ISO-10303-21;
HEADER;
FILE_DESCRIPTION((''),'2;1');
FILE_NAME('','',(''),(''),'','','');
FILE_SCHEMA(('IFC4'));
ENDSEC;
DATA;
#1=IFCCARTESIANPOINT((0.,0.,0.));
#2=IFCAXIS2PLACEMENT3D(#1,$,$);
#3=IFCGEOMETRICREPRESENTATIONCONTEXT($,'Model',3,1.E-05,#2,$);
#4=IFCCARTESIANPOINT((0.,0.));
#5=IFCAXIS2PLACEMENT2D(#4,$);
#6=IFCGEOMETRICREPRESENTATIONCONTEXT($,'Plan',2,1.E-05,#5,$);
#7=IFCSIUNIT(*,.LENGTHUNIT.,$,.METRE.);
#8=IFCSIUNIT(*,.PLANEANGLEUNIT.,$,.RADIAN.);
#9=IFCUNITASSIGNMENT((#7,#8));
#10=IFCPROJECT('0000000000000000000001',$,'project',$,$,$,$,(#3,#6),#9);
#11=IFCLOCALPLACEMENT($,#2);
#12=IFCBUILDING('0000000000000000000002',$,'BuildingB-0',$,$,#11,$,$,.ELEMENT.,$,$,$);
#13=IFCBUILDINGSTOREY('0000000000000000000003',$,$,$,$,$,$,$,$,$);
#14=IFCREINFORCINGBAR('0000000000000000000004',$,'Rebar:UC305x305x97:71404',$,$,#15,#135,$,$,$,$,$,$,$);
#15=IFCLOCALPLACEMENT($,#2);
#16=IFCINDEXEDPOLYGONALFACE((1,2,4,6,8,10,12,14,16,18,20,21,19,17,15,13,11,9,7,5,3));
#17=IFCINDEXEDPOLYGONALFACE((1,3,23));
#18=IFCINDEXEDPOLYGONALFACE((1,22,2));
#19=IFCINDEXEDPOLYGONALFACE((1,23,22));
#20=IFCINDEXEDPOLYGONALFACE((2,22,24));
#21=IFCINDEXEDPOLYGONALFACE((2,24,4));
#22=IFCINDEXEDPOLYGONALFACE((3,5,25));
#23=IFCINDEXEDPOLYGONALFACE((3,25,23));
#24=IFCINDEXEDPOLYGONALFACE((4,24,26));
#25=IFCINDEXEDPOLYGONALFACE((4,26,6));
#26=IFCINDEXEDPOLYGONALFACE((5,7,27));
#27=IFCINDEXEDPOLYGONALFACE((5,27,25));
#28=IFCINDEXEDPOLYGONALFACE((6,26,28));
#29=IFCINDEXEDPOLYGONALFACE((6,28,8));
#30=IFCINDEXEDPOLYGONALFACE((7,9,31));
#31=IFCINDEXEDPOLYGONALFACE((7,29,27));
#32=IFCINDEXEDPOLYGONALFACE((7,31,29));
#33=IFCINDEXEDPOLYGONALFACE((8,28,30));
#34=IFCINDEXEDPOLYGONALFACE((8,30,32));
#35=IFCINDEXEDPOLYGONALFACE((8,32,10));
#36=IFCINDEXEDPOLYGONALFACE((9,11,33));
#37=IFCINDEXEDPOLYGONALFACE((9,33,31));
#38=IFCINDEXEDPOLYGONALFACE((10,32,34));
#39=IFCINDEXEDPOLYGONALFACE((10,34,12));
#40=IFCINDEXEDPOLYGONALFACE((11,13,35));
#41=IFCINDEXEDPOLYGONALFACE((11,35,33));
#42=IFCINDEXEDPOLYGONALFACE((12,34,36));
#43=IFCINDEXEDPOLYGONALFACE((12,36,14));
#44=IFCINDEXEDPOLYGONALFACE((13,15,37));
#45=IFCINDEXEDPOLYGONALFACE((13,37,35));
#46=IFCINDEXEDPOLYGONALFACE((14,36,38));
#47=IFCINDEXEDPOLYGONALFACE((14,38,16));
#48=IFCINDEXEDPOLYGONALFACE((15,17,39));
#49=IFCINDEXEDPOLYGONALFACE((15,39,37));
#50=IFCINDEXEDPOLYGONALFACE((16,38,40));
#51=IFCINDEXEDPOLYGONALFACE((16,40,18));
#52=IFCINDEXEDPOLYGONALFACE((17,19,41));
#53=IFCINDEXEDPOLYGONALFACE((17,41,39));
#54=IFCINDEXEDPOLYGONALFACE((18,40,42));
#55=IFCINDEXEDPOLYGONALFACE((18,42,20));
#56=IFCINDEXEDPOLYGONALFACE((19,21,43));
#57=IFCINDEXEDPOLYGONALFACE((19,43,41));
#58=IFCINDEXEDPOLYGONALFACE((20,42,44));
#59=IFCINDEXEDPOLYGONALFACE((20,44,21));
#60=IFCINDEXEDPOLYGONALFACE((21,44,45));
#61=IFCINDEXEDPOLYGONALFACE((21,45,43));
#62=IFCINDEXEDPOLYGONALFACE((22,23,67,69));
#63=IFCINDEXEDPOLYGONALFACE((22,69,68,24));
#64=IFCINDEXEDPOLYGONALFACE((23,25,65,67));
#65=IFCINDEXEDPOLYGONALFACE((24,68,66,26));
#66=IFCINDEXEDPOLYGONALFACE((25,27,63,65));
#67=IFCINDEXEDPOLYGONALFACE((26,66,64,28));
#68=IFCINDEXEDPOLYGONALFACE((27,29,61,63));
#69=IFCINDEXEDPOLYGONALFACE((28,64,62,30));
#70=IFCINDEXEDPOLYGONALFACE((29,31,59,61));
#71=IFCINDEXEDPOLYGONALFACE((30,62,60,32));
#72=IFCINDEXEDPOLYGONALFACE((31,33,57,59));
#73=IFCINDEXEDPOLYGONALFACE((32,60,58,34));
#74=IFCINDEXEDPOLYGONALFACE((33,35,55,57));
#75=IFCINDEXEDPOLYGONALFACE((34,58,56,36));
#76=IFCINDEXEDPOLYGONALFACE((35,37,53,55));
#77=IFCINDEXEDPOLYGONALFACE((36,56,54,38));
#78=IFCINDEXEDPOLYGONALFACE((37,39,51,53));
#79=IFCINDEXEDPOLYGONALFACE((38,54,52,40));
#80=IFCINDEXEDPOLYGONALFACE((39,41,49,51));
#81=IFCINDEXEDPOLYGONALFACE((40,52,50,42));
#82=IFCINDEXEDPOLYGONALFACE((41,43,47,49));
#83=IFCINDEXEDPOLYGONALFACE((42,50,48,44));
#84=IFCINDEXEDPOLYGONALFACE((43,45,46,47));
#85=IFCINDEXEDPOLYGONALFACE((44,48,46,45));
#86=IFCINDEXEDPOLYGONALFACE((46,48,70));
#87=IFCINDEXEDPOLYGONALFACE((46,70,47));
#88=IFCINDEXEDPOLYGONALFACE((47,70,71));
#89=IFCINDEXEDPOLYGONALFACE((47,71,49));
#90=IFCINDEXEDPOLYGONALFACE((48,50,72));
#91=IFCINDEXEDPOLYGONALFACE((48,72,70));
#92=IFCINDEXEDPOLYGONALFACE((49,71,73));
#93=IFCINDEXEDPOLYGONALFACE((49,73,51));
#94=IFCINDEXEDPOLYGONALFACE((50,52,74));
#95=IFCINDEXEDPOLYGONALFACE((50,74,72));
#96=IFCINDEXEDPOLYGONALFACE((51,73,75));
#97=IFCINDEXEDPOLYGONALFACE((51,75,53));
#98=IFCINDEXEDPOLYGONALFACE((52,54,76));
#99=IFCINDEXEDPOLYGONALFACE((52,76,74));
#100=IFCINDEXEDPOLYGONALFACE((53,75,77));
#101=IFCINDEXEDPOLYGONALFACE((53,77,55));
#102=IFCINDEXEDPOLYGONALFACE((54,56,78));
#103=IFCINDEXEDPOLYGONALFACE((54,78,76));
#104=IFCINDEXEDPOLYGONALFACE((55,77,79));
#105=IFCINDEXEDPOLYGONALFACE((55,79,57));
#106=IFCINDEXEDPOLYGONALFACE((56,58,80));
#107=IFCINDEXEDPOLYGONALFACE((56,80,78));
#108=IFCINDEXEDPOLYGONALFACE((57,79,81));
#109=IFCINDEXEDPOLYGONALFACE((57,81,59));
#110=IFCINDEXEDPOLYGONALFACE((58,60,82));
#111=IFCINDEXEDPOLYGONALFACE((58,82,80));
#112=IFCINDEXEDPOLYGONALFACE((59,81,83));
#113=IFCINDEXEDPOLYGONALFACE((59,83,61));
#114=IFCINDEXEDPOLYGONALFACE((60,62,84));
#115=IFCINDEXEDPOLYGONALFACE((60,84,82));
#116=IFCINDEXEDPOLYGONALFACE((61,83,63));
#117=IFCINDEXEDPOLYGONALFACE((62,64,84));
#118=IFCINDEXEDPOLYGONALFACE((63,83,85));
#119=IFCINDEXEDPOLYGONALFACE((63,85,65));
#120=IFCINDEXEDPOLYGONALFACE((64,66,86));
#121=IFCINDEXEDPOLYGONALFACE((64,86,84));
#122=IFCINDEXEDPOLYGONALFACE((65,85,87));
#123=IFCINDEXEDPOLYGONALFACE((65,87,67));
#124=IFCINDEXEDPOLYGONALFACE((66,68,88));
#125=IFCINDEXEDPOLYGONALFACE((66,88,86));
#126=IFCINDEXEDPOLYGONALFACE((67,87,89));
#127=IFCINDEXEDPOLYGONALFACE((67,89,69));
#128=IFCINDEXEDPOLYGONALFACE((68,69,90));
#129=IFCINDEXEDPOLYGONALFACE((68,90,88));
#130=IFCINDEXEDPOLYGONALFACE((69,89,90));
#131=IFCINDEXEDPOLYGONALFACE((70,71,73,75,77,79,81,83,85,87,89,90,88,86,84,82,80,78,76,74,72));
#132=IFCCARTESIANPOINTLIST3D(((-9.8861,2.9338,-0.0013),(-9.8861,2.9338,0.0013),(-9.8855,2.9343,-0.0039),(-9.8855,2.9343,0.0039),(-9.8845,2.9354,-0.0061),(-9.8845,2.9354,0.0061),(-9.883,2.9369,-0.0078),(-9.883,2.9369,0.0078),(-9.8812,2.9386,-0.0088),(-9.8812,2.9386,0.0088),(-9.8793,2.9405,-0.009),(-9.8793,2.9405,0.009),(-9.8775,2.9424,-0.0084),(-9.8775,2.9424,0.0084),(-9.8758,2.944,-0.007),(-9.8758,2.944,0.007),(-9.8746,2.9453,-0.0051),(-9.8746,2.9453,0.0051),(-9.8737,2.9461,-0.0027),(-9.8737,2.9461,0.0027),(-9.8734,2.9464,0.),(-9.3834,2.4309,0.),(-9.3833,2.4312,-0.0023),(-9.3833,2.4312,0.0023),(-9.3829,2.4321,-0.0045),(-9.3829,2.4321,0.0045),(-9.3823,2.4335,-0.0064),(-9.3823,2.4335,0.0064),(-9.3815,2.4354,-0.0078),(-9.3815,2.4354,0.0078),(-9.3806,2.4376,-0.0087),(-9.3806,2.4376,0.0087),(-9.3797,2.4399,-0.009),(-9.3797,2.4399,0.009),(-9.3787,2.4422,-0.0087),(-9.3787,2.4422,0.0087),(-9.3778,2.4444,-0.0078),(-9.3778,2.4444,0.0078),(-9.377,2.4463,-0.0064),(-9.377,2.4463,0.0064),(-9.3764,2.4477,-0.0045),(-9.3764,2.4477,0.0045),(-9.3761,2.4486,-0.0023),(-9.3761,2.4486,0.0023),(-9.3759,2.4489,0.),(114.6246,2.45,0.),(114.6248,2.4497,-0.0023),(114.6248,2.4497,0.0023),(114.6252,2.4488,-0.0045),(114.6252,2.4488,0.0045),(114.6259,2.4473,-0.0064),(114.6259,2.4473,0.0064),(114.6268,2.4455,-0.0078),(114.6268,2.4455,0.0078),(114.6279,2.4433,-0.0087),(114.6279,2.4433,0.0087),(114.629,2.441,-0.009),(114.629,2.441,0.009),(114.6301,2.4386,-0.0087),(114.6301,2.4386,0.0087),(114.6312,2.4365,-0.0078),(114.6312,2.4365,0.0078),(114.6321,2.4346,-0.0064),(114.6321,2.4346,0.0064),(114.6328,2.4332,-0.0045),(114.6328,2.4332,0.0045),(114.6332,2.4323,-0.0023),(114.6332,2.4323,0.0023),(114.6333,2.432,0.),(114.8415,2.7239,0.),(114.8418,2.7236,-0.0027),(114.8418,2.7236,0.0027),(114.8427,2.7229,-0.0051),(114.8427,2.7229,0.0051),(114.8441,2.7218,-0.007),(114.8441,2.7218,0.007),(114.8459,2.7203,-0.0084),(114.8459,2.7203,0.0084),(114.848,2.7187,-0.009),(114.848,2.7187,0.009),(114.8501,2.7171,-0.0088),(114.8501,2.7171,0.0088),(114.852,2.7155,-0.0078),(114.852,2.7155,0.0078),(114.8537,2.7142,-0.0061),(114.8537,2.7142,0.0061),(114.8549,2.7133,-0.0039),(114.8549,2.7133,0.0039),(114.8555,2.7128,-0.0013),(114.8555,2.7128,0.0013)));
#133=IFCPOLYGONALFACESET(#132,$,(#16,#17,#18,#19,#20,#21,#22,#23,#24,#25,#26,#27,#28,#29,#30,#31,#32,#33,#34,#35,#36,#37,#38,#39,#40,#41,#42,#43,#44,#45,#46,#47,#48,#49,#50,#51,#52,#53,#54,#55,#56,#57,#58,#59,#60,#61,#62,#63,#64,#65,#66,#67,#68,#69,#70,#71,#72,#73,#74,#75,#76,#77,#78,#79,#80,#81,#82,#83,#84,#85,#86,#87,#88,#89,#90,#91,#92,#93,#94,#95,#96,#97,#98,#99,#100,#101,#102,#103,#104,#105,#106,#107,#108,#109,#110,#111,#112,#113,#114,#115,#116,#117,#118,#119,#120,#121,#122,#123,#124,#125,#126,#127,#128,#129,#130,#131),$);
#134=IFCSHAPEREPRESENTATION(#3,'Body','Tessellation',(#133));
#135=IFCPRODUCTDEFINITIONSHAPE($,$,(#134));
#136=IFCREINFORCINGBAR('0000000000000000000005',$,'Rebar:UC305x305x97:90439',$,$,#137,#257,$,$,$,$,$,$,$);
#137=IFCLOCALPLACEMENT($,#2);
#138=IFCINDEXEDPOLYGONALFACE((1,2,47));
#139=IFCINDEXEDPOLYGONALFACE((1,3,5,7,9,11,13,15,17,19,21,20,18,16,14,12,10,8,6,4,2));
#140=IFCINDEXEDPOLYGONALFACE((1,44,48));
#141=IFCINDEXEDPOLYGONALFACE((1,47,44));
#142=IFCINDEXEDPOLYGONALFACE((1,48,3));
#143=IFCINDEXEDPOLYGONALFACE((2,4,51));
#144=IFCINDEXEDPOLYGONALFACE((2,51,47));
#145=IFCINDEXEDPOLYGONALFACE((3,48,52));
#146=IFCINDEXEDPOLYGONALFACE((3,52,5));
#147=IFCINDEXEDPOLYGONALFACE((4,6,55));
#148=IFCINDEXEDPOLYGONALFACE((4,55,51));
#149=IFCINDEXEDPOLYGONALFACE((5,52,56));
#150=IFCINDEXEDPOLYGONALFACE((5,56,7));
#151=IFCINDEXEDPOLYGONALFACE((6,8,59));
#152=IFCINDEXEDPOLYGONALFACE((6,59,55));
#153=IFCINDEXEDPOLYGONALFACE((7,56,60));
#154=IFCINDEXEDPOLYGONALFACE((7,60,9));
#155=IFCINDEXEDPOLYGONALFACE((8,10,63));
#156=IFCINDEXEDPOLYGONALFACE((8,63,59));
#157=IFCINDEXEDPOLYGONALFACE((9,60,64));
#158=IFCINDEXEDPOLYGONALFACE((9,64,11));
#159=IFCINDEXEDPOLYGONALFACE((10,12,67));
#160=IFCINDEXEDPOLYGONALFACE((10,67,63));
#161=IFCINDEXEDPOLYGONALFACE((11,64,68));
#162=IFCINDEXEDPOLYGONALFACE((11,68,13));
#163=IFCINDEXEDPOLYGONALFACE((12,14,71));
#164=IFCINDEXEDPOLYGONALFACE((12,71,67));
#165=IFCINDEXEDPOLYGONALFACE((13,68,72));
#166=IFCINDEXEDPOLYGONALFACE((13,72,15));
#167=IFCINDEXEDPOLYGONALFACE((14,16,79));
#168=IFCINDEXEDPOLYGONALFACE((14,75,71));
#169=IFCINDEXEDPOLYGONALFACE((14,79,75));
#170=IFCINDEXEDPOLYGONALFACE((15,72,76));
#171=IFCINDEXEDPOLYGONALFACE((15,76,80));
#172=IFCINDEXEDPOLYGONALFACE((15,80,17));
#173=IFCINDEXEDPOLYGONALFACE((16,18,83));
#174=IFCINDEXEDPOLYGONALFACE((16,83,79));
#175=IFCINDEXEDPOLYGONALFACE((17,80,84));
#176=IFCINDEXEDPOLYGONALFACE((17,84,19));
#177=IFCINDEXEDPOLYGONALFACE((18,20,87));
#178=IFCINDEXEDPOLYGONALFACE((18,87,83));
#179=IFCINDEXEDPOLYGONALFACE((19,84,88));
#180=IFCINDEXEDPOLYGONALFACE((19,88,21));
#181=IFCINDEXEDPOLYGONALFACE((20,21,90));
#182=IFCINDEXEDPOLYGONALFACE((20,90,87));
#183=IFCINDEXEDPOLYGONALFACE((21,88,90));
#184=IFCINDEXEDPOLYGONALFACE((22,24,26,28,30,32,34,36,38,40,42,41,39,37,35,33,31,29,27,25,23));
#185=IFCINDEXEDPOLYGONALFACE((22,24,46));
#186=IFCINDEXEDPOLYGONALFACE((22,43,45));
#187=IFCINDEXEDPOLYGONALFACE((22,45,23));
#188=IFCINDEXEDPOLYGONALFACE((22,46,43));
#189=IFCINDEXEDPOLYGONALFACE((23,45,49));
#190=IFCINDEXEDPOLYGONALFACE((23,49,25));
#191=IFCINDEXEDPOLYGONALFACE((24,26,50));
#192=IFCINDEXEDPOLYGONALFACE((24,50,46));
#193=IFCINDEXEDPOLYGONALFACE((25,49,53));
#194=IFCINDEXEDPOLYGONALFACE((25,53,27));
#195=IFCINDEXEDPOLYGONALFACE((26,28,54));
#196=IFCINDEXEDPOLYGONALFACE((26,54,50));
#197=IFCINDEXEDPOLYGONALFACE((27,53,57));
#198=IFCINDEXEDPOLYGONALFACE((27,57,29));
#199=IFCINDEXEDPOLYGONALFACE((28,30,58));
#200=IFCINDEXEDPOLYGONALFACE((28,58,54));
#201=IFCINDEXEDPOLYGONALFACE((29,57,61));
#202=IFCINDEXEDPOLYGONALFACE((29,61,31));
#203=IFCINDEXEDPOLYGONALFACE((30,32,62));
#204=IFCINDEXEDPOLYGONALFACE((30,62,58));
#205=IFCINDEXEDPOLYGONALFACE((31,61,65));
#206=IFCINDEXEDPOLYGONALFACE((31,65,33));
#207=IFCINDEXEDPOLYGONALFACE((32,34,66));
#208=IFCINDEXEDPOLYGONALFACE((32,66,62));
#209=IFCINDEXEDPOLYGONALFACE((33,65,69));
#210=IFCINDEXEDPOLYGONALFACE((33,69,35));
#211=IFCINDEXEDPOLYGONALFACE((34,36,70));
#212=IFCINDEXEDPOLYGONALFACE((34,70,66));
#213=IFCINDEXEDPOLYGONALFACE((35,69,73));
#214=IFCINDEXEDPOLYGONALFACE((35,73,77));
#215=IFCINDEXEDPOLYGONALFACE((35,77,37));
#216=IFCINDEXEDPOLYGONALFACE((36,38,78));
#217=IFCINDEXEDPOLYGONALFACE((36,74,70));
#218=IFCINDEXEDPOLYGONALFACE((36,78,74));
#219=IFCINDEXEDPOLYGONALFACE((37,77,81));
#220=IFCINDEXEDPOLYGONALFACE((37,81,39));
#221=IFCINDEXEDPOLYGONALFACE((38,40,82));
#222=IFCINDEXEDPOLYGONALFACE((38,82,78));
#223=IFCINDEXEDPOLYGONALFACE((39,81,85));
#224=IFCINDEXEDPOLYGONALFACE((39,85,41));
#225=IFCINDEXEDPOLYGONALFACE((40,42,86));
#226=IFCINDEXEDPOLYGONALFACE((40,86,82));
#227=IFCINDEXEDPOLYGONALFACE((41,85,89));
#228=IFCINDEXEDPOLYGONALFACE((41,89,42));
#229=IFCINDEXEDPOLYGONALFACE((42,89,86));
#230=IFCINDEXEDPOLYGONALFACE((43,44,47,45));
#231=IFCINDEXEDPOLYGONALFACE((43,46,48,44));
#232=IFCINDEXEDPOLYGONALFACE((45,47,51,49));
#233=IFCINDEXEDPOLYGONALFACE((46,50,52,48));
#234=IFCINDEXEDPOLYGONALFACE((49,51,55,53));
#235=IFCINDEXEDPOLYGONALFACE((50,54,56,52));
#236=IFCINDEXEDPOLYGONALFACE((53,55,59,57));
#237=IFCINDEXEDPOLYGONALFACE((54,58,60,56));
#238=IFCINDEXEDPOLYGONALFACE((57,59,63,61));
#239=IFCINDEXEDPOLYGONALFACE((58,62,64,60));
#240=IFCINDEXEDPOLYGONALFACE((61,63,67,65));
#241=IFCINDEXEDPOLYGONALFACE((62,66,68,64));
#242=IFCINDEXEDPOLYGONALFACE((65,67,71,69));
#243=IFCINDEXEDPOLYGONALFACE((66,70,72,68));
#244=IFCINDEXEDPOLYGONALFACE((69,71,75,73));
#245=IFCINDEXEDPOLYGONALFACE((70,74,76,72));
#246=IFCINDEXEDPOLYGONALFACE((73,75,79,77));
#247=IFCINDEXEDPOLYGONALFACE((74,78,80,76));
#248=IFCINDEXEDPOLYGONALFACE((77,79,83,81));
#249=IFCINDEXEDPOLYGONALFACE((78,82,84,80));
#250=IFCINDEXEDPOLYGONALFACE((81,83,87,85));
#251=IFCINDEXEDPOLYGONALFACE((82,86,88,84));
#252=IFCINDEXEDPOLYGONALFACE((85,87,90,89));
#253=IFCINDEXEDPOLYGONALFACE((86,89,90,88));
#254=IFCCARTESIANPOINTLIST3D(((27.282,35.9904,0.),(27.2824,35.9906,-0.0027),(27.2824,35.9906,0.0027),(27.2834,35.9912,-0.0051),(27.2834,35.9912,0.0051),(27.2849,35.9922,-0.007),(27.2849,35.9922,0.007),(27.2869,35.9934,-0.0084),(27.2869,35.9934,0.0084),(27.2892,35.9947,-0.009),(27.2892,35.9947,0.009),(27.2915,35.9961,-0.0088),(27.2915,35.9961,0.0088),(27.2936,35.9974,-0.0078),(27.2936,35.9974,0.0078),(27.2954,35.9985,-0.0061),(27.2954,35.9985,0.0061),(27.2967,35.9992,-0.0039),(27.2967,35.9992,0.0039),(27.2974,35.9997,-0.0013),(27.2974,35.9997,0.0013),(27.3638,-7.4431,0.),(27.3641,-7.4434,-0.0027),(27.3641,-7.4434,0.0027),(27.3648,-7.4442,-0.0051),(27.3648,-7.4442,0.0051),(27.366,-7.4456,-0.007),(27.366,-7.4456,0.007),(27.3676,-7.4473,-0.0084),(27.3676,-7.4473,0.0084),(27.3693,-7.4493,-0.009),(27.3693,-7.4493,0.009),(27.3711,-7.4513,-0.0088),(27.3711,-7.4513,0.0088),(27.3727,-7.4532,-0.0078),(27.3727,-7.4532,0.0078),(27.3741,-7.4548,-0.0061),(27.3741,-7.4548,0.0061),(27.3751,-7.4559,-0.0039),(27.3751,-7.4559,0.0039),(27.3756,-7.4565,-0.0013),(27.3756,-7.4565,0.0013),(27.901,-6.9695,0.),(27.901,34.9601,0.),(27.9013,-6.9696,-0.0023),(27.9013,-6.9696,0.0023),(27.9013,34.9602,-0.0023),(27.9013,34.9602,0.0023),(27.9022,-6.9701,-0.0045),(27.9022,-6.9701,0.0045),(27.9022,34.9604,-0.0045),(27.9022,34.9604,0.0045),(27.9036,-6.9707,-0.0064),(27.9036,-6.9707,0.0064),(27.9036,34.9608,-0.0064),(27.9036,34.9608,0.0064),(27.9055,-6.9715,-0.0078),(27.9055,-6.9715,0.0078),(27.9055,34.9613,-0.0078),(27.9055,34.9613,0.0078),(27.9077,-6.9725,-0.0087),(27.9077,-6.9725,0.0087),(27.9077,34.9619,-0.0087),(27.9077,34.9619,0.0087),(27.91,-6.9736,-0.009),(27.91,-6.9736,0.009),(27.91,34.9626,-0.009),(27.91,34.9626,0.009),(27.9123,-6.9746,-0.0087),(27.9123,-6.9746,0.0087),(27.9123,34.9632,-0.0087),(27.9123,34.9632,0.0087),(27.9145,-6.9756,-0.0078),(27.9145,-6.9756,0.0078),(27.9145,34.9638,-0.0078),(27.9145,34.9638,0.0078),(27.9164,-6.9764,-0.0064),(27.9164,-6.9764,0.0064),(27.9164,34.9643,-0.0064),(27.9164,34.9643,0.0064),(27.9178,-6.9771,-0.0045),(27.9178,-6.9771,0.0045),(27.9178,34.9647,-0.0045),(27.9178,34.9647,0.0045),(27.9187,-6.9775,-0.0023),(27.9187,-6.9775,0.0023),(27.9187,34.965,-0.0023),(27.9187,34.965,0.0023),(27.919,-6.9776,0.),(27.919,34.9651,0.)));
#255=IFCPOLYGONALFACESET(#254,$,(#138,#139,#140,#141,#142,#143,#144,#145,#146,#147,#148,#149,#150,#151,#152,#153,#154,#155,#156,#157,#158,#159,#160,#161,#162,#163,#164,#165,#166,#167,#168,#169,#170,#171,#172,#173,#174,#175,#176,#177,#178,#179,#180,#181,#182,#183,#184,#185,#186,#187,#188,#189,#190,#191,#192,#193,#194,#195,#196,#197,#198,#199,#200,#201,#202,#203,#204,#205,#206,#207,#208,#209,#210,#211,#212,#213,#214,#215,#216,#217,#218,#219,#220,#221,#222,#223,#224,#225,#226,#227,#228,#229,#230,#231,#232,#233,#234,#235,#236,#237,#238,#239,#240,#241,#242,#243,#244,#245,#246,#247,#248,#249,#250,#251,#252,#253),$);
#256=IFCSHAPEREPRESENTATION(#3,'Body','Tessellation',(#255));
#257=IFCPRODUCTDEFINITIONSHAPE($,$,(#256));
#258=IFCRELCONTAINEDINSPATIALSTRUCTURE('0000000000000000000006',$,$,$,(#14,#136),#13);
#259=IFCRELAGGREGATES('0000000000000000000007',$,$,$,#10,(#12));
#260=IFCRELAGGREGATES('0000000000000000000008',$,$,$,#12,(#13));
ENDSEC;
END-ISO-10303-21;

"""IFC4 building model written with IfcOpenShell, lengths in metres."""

from ifc_helpers import new_model, entity, si_unit, origin, origin_2d, place, context, project, spatial, element, save


model = new_model("IFC4")

# Units and contexts
model_context = context("Model", 3, precision=1e-05, world=origin())
plan_context = context("Plan", 2, precision=1e-05, world=origin_2d())
ifc_project = project(units=[si_unit("LENGTHUNIT", "METRE"), si_unit("PLANEANGLEUNIT", "RADIAN")], contexts=[model_context, plan_context])

# Building, storey
building_placement = place(None, origin())
building = spatial("IfcBuilding", under=ifc_project, at=building_placement, Name="BuildingB-0", CompositionType="ELEMENT")
storey = spatial("IfcBuildingStorey", under=building)

# Reinforcing bars
element("IfcReinforcingBar", 1, inside=storey, Name="Rebar:UC305x305x97:71404", context=model_context, shape_type="SweptSolid", body=[
    entity("IfcSurfaceCurveSweptAreaSolid", entity("IfcCircleProfileDef", "AREA", None, None, 0.009), None, entity("IfcPolyline", [entity("IfcCartesianPoint", [114.8485, 2.7183, 0.0]), entity("IfcCartesianPoint", [114.629, 2.441, 0.0]), entity("IfcCartesianPoint", [-9.3797, 2.4399, 0.0]), entity("IfcCartesianPoint", [-9.8798, 2.9401, 0.0])]), None, None, entity("IfcPlane", entity("IfcAxis2Placement3D", entity("IfcCartesianPoint", [114.8485, 2.7183, 0.0]), entity("IfcDirection", [0.000009, -1.0, 0.0]), entity("IfcDirection", [-1.0, -0.000009, 0.0])))),
])
element("IfcReinforcingBar", 2, inside=storey, Name="Rebar:UC305x305x97:90439", context=model_context, shape_type="SweptSolid", body=[
    entity("IfcSurfaceCurveSweptAreaSolid", entity("IfcCircleProfileDef", "AREA", None, None, 0.009), None, entity("IfcPolyline", [entity("IfcCartesianPoint", [27.3697, -7.4498, 0.0]), entity("IfcCartesianPoint", [27.91, -6.9736, 0.0]), entity("IfcCartesianPoint", [27.91, 34.9626, 0.0]), entity("IfcCartesianPoint", [27.2897, 35.9951, 0.0])]), None, None, entity("IfcPlane", entity("IfcAxis2Placement3D", entity("IfcCartesianPoint", [27.3697, -7.4498, 0.0]), entity("IfcDirection", [1.0, -0.000167, 0.0]), entity("IfcDirection", [0.0, 1.0, 0.0])))),
])

save(model, "model.ifc")
